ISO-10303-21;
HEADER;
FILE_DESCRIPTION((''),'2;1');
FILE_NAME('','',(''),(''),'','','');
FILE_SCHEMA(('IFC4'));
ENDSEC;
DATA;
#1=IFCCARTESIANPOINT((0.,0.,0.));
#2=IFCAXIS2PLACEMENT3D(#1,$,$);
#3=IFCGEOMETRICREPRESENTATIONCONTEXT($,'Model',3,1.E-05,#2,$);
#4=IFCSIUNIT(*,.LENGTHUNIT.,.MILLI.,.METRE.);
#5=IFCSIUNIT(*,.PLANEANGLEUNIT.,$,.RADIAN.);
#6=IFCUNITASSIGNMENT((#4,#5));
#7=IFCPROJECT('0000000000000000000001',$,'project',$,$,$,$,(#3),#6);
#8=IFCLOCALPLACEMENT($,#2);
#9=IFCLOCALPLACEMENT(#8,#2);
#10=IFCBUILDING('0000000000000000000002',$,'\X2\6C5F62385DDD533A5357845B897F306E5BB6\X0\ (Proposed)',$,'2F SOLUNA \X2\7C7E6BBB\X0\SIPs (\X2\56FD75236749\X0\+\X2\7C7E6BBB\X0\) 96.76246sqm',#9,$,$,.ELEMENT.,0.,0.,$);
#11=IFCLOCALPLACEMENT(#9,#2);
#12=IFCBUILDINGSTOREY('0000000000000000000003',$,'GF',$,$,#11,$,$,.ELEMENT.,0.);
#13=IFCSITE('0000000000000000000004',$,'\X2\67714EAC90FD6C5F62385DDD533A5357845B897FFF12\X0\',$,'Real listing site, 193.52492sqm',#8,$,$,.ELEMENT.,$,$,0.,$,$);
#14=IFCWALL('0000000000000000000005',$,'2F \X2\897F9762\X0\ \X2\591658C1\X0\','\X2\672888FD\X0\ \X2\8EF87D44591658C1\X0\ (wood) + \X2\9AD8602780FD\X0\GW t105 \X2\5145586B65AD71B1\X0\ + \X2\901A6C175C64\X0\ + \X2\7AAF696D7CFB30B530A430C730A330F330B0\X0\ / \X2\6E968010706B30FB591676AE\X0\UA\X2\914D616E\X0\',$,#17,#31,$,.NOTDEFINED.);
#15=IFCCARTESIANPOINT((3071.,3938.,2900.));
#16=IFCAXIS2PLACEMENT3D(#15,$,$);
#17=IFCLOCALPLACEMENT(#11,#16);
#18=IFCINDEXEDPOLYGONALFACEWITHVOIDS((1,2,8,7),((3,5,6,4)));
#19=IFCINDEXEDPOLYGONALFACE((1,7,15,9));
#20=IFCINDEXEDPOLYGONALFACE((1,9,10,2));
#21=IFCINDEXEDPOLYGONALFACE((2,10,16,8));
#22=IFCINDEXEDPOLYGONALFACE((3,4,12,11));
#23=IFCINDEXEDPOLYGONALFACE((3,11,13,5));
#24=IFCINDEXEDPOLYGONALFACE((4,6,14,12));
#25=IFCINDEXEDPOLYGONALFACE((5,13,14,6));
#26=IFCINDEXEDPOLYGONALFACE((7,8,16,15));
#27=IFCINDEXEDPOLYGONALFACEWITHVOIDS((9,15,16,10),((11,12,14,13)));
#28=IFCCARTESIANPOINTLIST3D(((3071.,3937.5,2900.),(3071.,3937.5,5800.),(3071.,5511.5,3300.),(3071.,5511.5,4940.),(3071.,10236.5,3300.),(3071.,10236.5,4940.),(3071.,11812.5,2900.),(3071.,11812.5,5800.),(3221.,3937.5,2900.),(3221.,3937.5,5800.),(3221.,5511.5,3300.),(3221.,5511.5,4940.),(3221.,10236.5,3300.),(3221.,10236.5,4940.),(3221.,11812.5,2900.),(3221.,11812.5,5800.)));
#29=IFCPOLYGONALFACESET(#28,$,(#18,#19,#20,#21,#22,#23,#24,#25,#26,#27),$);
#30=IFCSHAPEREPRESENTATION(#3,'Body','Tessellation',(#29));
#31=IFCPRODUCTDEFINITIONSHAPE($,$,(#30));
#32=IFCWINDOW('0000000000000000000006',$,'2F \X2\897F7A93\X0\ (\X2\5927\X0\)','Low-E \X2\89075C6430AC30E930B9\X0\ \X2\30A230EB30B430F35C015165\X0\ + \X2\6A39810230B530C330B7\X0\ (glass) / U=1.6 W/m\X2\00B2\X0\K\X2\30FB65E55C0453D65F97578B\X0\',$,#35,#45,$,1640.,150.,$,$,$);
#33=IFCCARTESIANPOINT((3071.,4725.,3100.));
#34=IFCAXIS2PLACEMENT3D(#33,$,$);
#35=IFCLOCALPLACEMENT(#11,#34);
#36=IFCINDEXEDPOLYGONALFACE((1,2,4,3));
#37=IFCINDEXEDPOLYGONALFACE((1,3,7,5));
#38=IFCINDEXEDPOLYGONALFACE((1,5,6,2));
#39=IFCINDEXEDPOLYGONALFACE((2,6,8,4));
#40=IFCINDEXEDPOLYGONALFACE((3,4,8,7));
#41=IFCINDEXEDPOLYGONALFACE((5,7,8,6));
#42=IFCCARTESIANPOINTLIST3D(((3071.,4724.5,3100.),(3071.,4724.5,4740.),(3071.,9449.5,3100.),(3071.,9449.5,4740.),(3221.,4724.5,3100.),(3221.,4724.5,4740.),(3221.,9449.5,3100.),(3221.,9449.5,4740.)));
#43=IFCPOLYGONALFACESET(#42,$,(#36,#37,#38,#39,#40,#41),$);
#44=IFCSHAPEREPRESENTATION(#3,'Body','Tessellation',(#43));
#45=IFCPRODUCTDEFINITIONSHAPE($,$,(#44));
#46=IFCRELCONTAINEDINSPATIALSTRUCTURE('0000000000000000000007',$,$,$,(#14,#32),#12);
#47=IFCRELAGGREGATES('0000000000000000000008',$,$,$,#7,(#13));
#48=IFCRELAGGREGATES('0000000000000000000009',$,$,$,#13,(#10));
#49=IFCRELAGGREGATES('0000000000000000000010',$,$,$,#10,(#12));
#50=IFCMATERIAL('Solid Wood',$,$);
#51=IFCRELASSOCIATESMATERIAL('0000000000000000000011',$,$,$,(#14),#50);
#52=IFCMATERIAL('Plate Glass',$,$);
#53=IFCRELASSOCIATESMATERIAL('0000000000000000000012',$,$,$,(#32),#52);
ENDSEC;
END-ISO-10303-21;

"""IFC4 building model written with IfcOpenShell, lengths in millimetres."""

from ifc_helpers import new_model, si_unit, frame, frame_2d, origin, place, context, project, spatial, rectangle, extrude, material, element, fill, save


model = new_model("IFC4")

# Units and contexts
model_context = context("Model", 3, precision=1e-05, world=origin())
ifc_project = project(units=[si_unit("LENGTHUNIT", "METRE", prefix="MILLI"), si_unit("PLANEANGLEUNIT", "RADIAN")], contexts=[model_context])

# Site, building, storey
site_placement = place(None, origin())
site = spatial("IfcSite", under=ifc_project, at=site_placement, Name="東京都江戸川区南葛西２", ObjectType="Real listing site, 193.52492sqm", CompositionType="ELEMENT", RefElevation=0.0)
building_placement = place(site_placement, origin())
building = spatial("IfcBuilding", under=site, at=building_placement, Name="江戸川区南葛西の家 (Proposed)", ObjectType="2F SOLUNA 籾殻SIPs (国産杉+籾殻) 96.76246sqm", CompositionType="ELEMENT", ElevationOfRefHeight=0.0, ElevationOfTerrain=0.0)
storey_placement = place(building_placement, origin())
storey = spatial("IfcBuildingStorey", under=building, at=storey_placement, Name="GF", CompositionType="ELEMENT", Elevation=0.0)

# Shared definitions
ifc_material_1 = material(Name="Solid Wood")

# Shared definitions
ifc_material_2 = material(Name="Plate Glass")

# Wall, opening, window
wall_1_placement = place(storey_placement, frame((3071.0, 3938.0, 2900.0)))
wall_1 = element("IfcWall", 1, at=wall_1_placement, inside=storey, material=ifc_material_1, Name="2F 西面 外壁", Description="木製 軸組外壁 (wood) + 高性能GW t105 充填断熱 + 通気層 + 窯業系サイディング / 準耐火・外皮UA配慮", PredefinedType="NOTDEFINED", context=model_context, shape_type="SweptSolid", body=[
    extrude(rectangle(XDim=150.0, YDim=7875.0, at=frame_2d((75.0, 3937.0))), frame((3071.0, 3938.0, 2900.0)), (0.0, 0.0, 1.0), 2900.0),
])
opening_1_placement = place(storey_placement, frame((3071.0, 4725.0, 3100.0)))
opening_1 = element("IfcOpeningElement", 2, at=opening_1_placement, cuts=wall_1, PredefinedType="NOTDEFINED", context=model_context, shape_type="SweptSolid", body=[
    extrude(rectangle(XDim=150.0, YDim=4725.0, at=frame_2d((75.0, 2362.0))), frame((3071.0, 4725.0, 3100.0)), (0.0, 0.0, 1.0), 1640.0),
])
window_1_placement = place(storey_placement, frame((3071.0, 4725.0, 3100.0)))
window_1 = element("IfcWindow", 3, at=window_1_placement, inside=storey, material=ifc_material_2, Name="2F 西窓 (大)", Description="Low-E 複層ガラス アルゴン封入 + 樹脂サッシ (glass) / U=1.6 W/m²K・日射取得型", OverallHeight=1640.0, OverallWidth=150.0, context=model_context, shape_type="SweptSolid", body=[
    extrude(rectangle(XDim=150.0, YDim=4725.0, at=frame_2d((75.0, 2362.0))), frame((3071.0, 4725.0, 3100.0)), (0.0, 0.0, 1.0), 1640.0),
])
fill(opening_1, window_1)

save(model, "model.ifc")
